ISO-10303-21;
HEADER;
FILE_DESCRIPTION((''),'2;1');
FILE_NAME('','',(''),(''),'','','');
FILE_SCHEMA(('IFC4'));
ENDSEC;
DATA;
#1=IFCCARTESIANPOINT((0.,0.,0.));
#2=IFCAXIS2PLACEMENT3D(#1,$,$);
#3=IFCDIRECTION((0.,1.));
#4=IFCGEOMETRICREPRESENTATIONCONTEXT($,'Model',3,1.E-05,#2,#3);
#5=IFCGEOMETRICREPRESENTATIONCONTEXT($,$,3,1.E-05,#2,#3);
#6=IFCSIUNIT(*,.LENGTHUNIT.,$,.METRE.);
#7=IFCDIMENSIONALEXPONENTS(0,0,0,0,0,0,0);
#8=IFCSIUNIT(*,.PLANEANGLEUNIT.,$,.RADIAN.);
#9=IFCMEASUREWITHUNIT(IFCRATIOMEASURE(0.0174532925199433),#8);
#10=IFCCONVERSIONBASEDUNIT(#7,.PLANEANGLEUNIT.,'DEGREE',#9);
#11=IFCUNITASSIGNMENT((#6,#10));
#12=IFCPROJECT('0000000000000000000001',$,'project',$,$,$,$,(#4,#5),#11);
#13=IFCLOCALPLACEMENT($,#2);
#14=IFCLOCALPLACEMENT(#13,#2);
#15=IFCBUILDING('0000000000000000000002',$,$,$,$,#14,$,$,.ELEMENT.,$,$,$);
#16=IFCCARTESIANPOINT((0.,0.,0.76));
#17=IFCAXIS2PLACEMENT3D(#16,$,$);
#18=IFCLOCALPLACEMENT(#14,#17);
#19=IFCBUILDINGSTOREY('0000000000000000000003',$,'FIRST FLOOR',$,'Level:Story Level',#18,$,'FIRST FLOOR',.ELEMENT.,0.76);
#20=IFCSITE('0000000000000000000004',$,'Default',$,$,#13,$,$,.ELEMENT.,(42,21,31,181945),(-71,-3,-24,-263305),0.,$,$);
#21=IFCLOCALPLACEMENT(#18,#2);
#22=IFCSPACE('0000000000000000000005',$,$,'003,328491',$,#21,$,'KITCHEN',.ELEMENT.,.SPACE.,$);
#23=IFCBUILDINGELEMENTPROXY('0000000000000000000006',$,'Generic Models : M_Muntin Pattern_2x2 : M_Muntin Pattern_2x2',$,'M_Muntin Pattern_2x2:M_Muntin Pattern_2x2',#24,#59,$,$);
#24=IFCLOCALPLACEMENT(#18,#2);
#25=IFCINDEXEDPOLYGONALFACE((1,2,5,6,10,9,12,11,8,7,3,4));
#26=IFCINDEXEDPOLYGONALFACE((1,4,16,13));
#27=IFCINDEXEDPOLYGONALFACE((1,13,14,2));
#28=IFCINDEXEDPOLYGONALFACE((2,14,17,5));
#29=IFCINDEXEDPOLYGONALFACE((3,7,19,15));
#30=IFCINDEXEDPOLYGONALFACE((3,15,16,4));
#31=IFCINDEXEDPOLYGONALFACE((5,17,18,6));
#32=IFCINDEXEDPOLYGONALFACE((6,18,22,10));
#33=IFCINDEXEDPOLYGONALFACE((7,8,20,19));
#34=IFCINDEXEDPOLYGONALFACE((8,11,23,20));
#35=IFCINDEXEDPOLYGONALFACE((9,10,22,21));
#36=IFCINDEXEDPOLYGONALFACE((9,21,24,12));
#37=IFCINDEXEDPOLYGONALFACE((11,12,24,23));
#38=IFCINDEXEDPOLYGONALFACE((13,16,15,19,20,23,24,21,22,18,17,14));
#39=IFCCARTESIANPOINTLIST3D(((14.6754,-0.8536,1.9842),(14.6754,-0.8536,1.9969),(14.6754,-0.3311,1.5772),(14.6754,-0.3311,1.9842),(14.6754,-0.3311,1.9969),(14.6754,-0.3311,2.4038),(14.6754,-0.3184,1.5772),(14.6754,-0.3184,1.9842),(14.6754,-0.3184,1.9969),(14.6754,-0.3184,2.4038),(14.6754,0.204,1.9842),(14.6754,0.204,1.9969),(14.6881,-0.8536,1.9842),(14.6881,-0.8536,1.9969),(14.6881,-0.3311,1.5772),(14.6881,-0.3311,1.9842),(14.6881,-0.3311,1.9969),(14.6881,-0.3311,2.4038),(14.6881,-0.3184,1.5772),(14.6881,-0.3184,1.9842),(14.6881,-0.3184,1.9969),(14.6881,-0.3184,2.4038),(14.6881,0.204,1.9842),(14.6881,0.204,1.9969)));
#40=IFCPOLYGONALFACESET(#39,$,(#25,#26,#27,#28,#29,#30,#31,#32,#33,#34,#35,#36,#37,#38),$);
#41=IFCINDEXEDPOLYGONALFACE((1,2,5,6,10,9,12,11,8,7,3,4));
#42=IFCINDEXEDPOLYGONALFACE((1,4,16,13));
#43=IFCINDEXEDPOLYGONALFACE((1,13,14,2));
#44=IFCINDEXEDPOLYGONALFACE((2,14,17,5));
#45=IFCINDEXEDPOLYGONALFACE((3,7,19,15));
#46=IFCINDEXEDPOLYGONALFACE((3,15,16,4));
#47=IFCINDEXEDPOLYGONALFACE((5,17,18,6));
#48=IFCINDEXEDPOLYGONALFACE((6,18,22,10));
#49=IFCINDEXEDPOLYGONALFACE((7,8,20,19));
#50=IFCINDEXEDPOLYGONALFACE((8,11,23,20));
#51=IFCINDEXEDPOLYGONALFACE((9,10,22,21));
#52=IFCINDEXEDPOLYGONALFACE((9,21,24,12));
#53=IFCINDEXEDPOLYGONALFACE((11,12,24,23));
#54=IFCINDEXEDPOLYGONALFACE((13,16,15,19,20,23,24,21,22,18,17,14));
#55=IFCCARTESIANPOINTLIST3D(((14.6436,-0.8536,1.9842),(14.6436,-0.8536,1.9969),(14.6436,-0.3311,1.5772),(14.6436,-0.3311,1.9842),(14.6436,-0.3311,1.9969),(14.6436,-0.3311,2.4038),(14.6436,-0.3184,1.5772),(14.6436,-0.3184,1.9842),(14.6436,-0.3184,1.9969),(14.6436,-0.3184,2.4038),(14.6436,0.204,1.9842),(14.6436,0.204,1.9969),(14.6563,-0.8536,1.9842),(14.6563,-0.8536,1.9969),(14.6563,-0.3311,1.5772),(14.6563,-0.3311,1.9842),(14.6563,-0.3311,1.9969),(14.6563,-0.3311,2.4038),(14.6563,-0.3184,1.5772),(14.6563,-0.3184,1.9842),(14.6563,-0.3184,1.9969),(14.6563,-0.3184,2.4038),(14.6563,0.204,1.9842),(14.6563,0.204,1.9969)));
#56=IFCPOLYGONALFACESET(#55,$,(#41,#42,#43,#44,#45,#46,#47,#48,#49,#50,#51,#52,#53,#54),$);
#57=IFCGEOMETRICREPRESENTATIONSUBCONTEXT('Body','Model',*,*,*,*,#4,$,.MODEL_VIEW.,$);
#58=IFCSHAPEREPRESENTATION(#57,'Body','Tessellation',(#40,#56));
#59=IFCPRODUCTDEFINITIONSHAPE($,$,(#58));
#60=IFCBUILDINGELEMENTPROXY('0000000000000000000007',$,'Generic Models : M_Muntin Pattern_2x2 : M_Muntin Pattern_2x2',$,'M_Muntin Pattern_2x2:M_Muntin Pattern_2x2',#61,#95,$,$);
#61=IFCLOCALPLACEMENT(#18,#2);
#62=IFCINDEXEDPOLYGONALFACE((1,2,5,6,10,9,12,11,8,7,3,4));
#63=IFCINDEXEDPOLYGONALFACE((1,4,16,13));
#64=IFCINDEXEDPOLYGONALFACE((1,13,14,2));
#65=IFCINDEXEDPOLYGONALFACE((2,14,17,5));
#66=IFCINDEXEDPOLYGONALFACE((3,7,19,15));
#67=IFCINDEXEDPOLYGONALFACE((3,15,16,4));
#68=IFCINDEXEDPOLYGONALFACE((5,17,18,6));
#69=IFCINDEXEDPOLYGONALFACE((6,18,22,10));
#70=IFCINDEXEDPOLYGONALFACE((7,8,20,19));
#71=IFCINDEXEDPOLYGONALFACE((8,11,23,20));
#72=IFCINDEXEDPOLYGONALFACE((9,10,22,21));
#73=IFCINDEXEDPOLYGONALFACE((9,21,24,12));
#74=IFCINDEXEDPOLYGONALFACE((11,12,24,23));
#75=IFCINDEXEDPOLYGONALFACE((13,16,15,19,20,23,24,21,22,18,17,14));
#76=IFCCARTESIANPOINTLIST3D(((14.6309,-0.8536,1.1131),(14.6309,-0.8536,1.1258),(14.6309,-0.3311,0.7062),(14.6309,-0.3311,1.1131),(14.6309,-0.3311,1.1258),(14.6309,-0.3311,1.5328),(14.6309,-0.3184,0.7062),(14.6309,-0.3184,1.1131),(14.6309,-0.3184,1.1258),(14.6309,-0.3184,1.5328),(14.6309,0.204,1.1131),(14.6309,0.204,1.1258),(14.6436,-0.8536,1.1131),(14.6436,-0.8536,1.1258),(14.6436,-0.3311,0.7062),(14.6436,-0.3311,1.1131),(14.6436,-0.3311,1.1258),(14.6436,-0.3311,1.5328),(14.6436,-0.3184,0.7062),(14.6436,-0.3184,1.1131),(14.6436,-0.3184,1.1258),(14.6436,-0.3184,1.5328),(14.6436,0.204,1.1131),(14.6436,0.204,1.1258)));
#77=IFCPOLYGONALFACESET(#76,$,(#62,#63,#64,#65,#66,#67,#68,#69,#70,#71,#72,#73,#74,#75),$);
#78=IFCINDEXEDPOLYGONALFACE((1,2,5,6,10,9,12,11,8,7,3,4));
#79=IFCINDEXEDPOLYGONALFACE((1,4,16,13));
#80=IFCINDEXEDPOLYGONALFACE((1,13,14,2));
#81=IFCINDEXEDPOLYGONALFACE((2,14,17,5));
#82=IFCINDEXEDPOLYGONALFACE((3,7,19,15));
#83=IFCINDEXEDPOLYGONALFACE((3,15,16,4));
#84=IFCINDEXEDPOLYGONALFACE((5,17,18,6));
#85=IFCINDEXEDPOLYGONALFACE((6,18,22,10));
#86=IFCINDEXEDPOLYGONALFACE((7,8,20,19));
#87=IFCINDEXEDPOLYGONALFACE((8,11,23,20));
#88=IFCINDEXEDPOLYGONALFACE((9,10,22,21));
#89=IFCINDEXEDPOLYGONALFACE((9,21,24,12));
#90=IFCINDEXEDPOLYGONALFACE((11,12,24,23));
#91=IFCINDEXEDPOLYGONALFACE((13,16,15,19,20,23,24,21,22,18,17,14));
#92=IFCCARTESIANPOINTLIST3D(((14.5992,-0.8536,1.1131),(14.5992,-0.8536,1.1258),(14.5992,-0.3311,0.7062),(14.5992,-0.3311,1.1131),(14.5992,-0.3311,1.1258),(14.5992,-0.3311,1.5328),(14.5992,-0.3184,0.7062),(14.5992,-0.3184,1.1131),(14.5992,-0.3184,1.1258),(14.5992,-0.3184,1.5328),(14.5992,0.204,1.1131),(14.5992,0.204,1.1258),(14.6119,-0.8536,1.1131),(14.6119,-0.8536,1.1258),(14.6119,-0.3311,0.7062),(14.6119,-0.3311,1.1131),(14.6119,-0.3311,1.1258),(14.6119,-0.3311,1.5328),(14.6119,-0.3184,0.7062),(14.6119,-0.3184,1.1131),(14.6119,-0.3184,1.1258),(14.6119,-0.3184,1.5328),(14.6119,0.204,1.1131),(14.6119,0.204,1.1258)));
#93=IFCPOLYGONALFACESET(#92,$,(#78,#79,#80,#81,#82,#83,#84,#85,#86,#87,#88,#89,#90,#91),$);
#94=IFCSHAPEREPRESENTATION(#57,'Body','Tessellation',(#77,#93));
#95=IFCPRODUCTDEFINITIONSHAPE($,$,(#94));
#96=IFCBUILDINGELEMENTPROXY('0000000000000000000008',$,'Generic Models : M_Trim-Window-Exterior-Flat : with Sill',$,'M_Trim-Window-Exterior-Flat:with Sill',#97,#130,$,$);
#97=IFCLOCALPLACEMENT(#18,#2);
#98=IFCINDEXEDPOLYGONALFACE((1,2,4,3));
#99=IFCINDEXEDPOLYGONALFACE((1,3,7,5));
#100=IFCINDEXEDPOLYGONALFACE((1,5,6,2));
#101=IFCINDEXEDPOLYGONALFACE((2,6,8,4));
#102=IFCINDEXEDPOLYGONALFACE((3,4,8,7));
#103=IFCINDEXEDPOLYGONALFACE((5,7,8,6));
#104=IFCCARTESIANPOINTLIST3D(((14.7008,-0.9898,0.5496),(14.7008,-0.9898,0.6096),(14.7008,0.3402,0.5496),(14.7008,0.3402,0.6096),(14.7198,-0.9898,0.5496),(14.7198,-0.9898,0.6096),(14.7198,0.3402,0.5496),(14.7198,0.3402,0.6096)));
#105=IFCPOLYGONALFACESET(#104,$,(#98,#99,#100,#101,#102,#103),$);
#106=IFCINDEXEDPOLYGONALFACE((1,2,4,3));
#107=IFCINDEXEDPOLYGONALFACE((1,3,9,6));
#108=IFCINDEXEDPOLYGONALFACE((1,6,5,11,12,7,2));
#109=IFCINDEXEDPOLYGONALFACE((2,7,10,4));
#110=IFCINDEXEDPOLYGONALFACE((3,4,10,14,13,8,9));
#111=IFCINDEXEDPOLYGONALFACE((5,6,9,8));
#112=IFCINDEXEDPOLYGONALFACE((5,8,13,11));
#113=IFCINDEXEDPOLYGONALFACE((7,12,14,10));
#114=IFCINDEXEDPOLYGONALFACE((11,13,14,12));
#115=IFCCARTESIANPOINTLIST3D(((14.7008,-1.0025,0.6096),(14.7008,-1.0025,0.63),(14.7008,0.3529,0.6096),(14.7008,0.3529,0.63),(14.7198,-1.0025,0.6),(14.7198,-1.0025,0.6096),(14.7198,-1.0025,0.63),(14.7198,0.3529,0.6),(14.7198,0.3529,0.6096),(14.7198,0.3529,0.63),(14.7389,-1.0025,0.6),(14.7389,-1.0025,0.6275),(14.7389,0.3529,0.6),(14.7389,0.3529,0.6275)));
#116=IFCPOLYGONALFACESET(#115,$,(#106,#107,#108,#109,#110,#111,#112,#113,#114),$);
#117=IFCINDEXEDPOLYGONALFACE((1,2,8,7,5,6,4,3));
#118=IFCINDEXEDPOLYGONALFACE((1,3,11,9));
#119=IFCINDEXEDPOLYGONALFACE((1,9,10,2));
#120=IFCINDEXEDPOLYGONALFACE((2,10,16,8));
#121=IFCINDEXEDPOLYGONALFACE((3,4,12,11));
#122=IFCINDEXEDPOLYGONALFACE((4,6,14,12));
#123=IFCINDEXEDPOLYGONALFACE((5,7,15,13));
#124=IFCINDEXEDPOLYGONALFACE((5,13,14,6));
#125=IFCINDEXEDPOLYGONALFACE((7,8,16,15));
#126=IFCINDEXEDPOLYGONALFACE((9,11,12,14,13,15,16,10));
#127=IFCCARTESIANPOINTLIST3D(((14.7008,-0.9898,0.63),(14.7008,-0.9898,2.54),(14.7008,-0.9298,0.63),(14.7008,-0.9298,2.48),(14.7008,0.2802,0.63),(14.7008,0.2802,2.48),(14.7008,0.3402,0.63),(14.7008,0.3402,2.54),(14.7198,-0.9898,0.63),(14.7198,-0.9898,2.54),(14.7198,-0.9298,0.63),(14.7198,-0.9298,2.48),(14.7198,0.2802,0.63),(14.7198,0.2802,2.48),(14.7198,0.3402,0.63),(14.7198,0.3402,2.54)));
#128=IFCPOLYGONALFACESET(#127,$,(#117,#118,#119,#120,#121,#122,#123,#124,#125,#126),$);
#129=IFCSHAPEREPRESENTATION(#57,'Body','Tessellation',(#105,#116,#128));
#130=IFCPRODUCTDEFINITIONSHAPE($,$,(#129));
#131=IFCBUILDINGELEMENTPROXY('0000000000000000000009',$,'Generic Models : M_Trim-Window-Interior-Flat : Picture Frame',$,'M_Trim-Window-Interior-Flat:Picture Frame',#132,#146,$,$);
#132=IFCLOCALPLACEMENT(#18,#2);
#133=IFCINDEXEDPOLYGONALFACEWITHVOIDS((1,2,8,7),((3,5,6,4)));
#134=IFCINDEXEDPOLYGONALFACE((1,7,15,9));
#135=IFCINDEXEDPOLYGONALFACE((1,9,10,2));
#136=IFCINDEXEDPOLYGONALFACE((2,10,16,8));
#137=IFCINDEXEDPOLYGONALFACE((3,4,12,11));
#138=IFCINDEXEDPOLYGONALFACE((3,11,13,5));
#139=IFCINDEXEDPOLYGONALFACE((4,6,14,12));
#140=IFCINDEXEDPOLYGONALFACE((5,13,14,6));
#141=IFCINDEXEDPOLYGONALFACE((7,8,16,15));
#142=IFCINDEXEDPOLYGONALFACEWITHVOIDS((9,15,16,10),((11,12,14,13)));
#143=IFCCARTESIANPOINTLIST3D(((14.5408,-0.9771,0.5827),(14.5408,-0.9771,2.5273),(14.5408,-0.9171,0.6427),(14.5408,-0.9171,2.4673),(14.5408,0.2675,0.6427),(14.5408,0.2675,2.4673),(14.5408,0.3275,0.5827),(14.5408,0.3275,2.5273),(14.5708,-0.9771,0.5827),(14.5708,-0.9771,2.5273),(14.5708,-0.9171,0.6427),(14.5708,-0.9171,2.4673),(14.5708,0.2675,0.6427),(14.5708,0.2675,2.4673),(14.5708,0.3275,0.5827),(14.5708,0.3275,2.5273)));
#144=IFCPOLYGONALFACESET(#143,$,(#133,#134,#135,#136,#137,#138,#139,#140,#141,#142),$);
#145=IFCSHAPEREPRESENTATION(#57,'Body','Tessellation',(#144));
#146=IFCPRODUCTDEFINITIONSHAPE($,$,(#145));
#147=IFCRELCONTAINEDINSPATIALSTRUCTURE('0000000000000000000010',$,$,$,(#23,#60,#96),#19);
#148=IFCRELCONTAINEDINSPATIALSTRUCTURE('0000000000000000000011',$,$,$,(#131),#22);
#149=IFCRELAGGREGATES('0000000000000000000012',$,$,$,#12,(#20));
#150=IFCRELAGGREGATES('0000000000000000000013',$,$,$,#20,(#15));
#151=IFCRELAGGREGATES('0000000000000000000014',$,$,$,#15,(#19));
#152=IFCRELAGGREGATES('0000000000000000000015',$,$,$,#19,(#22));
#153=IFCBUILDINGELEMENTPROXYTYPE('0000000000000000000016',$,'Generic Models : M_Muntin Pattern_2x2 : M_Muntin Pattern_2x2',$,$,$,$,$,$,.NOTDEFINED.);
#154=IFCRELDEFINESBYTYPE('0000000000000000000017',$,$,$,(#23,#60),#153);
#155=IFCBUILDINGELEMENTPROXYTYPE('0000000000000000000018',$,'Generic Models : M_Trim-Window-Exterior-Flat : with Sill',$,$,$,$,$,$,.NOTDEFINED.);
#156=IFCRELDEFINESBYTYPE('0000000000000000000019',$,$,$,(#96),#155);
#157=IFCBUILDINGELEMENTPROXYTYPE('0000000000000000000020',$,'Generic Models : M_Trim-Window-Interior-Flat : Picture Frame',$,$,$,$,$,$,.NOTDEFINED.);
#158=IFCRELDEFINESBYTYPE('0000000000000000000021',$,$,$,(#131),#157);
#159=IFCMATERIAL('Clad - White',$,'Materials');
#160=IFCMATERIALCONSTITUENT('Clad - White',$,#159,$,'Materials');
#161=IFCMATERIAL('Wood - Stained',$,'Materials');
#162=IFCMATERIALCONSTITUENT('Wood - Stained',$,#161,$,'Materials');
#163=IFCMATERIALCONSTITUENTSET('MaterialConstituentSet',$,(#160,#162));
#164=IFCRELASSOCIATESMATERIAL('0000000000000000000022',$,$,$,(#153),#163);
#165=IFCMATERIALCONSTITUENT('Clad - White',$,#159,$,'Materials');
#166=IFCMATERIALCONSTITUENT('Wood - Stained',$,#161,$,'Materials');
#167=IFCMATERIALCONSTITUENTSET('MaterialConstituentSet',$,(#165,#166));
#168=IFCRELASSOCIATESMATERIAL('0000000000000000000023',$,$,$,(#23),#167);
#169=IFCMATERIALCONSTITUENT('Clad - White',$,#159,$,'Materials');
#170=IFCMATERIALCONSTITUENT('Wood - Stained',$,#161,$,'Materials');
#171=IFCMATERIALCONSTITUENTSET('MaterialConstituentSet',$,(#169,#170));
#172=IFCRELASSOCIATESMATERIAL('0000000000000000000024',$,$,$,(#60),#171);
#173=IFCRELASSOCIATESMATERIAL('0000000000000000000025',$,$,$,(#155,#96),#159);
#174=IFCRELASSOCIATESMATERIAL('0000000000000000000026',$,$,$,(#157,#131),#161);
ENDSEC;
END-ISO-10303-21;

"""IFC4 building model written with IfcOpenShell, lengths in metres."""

from ifc_helpers import new_model, entity, si_unit, converted_unit, direction, frame, origin, origin_2d_with_axis, place, context, subcontext, project, spatial, polyline, rectangle, outline, extrude, source, transform, mapped, material, constituent, constituent_set, type_object, type_shapes, element, save


model = new_model("IFC4")

# Units and contexts
model_context = context("Model", 3, precision=1e-05, world=origin(), true_north=direction((0.0, 1.0)))
context_of_model = context(None, 3, precision=1e-05, world=origin(), true_north=direction((0.0, 1.0)))
body_context = subcontext(model_context, "Body", "Model", "MODEL_VIEW")
ifc_project = project(units=[si_unit("LENGTHUNIT", "METRE"), converted_unit("PLANEANGLEUNIT", "DEGREE", entity("IfcRatioMeasure", 0.0174532925199433), si_unit("PLANEANGLEUNIT", "RADIAN"), dimensions=[0, 0, 0, 0, 0, 0, 0])], contexts=[model_context, context_of_model])

# Site, building, storey
site_placement = place(None, origin())
site = spatial("IfcSite", under=ifc_project, at=site_placement, Name="Default", CompositionType="ELEMENT", RefLatitude=(42, 21, 31, 181945), RefLongitude=(-71, -3, -24, -263305), RefElevation=0.0)
building_placement = place(site_placement, origin())
building = spatial("IfcBuilding", under=site, at=building_placement, CompositionType="ELEMENT")
storey_placement = place(building_placement, frame((0.0, 0.0, 0.76)))
storey = spatial("IfcBuildingStorey", under=building, at=storey_placement, Name="FIRST FLOOR", ObjectType="Level:Story Level", LongName="FIRST FLOOR", CompositionType="ELEMENT", Elevation=0.76)

# Shared definitions
ifc_material_1 = material(Name="Wood - Stained", Category="Materials")

# Building element proxies
ifc_material_2 = material(Name="Clad - White", Category="Materials")
ifc_constituent_1 = constituent(ifc_material_2, Name="Clad - White", Category="Materials")
ifc_constituent_2 = constituent(ifc_material_1, Name="Wood - Stained", Category="Materials")
ifc_constituent_set_1 = constituent_set(constituents=[ifc_constituent_1, ifc_constituent_2], Name="MaterialConstituentSet")
ifc_constituent_3 = constituent(ifc_material_2, Name="Clad - White", Category="Materials")
ifc_constituent_4 = constituent(ifc_material_1, Name="Wood - Stained", Category="Materials")
ifc_constituent_set_2 = constituent_set(constituents=[ifc_constituent_3, ifc_constituent_4], Name="MaterialConstituentSet")
building_element_proxy_type_1 = type_object("IfcBuildingElementProxyType", Name="Generic Models : M_Muntin Pattern_2x2 : M_Muntin Pattern_2x2", PredefinedType="NOTDEFINED", material=ifc_constituent_set_2)
shared_shape_1 = source(origin(), body_context, "Body", "SweptSolid", [
    extrude(outline(polyline([(0.0064, -0.0064), (0.4133, -0.0064), (0.4133, 0.0063), (0.0064, 0.0063), (0.0064, 0.5288), (-0.0063, 0.5288), (-0.0063, 0.0063), (-0.4133, 0.0063), (-0.4133, -0.0064), (-0.0063, -0.0064), (-0.0063, -0.5288), (0.0064, -0.5288), (0.0064, -0.0064)])), frame((0.0, 0.0095, 0.4133), z_axis=(0.0, 1.0, 0.0), x_axis=(0.0, 0.0, 1.0)), (0.0, 0.0, 1.0), 0.0127),
    extrude(outline(polyline([(0.0064, -0.0064), (0.4133, -0.0064), (0.4133, 0.0063), (0.0064, 0.0063), (0.0064, 0.5288), (-0.0063, 0.5288), (-0.0063, 0.0063), (-0.4133, 0.0063), (-0.4133, -0.0064), (-0.0063, -0.0064), (-0.0063, -0.5288), (0.0064, -0.5288), (0.0064, -0.0064)])), frame((0.0, -0.0222, 0.4133), z_axis=(0.0, 1.0, 0.0), x_axis=(0.0, 0.0, 1.0)), (0.0, 0.0, 1.0), 0.0127),
])
type_shapes(building_element_proxy_type_1, [shared_shape_1])
proxy_1_placement = place(storey_placement, frame((14.6659, -0.3248, 1.5772), z_axis=(0.0, 0.0, 1.0), x_axis=(0.0, -1.0, 0.0)))
element("IfcBuildingElementProxy", 1, at=proxy_1_placement, inside=storey, type_object=building_element_proxy_type_1, material=ifc_constituent_set_1, Name="Generic Models : M_Muntin Pattern_2x2 : M_Muntin Pattern_2x2", ObjectType="M_Muntin Pattern_2x2:M_Muntin Pattern_2x2", context=body_context, shape_type="MappedRepresentation", body=[
    mapped(shared_shape_1, transform((0.0, 0.0, 0.0), scale=1.0)),
])
ifc_constituent_5 = constituent(ifc_material_2, Name="Clad - White", Category="Materials")
ifc_constituent_6 = constituent(ifc_material_1, Name="Wood - Stained", Category="Materials")
ifc_constituent_set_3 = constituent_set(constituents=[ifc_constituent_5, ifc_constituent_6], Name="MaterialConstituentSet")
proxy_2_placement = place(storey_placement, frame((14.6214, -0.3248, 0.7062), z_axis=(0.0, 0.0, 1.0), x_axis=(0.0, -1.0, 0.0)))
element("IfcBuildingElementProxy", 2, at=proxy_2_placement, inside=storey, type_object=building_element_proxy_type_1, material=ifc_constituent_set_3, Name="Generic Models : M_Muntin Pattern_2x2 : M_Muntin Pattern_2x2", ObjectType="M_Muntin Pattern_2x2:M_Muntin Pattern_2x2", context=body_context, shape_type="MappedRepresentation", body=[
    mapped(shared_shape_1, transform((0.0, 0.0, 0.0), scale=1.0)),
])
building_element_proxy_type_2 = type_object("IfcBuildingElementProxyType", Name="Generic Models : M_Trim-Window-Exterior-Flat : with Sill", PredefinedType="NOTDEFINED", material=ifc_material_2)
shared_shape_2 = source(origin(), body_context, "Body", "SweptSolid", [
    extrude(rectangle(XDim=1.33, YDim=0.06, at=origin_2d_with_axis()), frame((0.0, -1.9004, 0.0), z_axis=(0.0, 0.0, 1.0), x_axis=(-1.0, 0.0, 0.0)), (0.0, 0.0, 1.0), 0.0191),
    extrude(outline(polyline([(-0.019, -0.0152), (0.0, -0.0152), (0.0, -0.0057), (0.019, -0.0057), (0.019, 0.0148), (0.0, 0.0148), (-0.019, 0.0123), (-0.019, -0.0152)])), frame((-0.6777, -1.8648, 0.019), z_axis=(1.0, 0.0, 0.0), x_axis=(0.0, 0.0, -1.0)), (0.0, 0.0, 1.0), 1.3554),
    extrude(outline(polyline([(-0.97, -0.665), (0.94, -0.665), (0.94, -0.605), (-0.91, -0.605), (-0.91, 0.605), (0.94, 0.605), (0.94, 0.665), (-0.97, 0.665), (-0.97, -0.665)])), frame((0.0, -0.91, 0.0), z_axis=(0.0, 0.0, 1.0), x_axis=(0.0, -1.0, 0.0)), (0.0, 0.0, 1.0), 0.0191),
])
type_shapes(building_element_proxy_type_2, [shared_shape_2])
proxy_3_placement = place(storey_placement, frame((14.7008, -0.3248, 2.48), z_axis=(1.0, 0.0, 0.0), x_axis=(0.0, 1.0, 0.0)))
element("IfcBuildingElementProxy", 3, at=proxy_3_placement, inside=storey, type_object=building_element_proxy_type_2, material=ifc_material_2, Name="Generic Models : M_Trim-Window-Exterior-Flat : with Sill", ObjectType="M_Trim-Window-Exterior-Flat:with Sill", context=body_context, shape_type="MappedRepresentation", body=[
    mapped(shared_shape_2, transform((0.0, 0.0, 0.0), scale=1.0)),
])

# Shared definitions
space_1_placement = place(storey_placement, origin())
space_1 = spatial("IfcSpace", under=storey, at=space_1_placement, Description="003,328491", LongName="KITCHEN", CompositionType="ELEMENT", PredefinedType="SPACE")

# Building element proxy
building_element_proxy_type_3 = type_object("IfcBuildingElementProxyType", Name="Generic Models : M_Trim-Window-Interior-Flat : Picture Frame", PredefinedType="NOTDEFINED", material=ifc_material_1)
shared_shape_3 = source(origin(), body_context, "Body", "SweptSolid", [
    extrude(outline(polyline([(-0.6523, -0.9723), (0.6523, -0.9723), (0.6523, 0.9723), (-0.6523, 0.9723), (-0.6523, -0.9723)]), holes=[polyline([(-0.5923, -0.9123), (-0.5923, 0.9123), (0.5923, 0.9123), (0.5923, -0.9123), (-0.5923, -0.9123)])]), frame((0.0, -0.925, 0.0), z_axis=(0.0, 0.0, 1.0), x_axis=(-1.0, 0.0, 0.0)), (0.0, 0.0, 1.0), 0.03),
])
type_shapes(building_element_proxy_type_3, [shared_shape_3])
proxy_4_placement = place(space_1_placement, frame((14.5708, -0.3248, 2.48), z_axis=(-1.0, 0.0, 0.0), x_axis=(0.0, -1.0, 0.0)))
element("IfcBuildingElementProxy", 4, at=proxy_4_placement, inside=space_1, type_object=building_element_proxy_type_3, material=ifc_material_1, Name="Generic Models : M_Trim-Window-Interior-Flat : Picture Frame", ObjectType="M_Trim-Window-Interior-Flat:Picture Frame", context=body_context, shape_type="MappedRepresentation", body=[
    mapped(shared_shape_3, transform((0.0, 0.0, 0.0), scale=1.0)),
])

save(model, "model.ifc")
